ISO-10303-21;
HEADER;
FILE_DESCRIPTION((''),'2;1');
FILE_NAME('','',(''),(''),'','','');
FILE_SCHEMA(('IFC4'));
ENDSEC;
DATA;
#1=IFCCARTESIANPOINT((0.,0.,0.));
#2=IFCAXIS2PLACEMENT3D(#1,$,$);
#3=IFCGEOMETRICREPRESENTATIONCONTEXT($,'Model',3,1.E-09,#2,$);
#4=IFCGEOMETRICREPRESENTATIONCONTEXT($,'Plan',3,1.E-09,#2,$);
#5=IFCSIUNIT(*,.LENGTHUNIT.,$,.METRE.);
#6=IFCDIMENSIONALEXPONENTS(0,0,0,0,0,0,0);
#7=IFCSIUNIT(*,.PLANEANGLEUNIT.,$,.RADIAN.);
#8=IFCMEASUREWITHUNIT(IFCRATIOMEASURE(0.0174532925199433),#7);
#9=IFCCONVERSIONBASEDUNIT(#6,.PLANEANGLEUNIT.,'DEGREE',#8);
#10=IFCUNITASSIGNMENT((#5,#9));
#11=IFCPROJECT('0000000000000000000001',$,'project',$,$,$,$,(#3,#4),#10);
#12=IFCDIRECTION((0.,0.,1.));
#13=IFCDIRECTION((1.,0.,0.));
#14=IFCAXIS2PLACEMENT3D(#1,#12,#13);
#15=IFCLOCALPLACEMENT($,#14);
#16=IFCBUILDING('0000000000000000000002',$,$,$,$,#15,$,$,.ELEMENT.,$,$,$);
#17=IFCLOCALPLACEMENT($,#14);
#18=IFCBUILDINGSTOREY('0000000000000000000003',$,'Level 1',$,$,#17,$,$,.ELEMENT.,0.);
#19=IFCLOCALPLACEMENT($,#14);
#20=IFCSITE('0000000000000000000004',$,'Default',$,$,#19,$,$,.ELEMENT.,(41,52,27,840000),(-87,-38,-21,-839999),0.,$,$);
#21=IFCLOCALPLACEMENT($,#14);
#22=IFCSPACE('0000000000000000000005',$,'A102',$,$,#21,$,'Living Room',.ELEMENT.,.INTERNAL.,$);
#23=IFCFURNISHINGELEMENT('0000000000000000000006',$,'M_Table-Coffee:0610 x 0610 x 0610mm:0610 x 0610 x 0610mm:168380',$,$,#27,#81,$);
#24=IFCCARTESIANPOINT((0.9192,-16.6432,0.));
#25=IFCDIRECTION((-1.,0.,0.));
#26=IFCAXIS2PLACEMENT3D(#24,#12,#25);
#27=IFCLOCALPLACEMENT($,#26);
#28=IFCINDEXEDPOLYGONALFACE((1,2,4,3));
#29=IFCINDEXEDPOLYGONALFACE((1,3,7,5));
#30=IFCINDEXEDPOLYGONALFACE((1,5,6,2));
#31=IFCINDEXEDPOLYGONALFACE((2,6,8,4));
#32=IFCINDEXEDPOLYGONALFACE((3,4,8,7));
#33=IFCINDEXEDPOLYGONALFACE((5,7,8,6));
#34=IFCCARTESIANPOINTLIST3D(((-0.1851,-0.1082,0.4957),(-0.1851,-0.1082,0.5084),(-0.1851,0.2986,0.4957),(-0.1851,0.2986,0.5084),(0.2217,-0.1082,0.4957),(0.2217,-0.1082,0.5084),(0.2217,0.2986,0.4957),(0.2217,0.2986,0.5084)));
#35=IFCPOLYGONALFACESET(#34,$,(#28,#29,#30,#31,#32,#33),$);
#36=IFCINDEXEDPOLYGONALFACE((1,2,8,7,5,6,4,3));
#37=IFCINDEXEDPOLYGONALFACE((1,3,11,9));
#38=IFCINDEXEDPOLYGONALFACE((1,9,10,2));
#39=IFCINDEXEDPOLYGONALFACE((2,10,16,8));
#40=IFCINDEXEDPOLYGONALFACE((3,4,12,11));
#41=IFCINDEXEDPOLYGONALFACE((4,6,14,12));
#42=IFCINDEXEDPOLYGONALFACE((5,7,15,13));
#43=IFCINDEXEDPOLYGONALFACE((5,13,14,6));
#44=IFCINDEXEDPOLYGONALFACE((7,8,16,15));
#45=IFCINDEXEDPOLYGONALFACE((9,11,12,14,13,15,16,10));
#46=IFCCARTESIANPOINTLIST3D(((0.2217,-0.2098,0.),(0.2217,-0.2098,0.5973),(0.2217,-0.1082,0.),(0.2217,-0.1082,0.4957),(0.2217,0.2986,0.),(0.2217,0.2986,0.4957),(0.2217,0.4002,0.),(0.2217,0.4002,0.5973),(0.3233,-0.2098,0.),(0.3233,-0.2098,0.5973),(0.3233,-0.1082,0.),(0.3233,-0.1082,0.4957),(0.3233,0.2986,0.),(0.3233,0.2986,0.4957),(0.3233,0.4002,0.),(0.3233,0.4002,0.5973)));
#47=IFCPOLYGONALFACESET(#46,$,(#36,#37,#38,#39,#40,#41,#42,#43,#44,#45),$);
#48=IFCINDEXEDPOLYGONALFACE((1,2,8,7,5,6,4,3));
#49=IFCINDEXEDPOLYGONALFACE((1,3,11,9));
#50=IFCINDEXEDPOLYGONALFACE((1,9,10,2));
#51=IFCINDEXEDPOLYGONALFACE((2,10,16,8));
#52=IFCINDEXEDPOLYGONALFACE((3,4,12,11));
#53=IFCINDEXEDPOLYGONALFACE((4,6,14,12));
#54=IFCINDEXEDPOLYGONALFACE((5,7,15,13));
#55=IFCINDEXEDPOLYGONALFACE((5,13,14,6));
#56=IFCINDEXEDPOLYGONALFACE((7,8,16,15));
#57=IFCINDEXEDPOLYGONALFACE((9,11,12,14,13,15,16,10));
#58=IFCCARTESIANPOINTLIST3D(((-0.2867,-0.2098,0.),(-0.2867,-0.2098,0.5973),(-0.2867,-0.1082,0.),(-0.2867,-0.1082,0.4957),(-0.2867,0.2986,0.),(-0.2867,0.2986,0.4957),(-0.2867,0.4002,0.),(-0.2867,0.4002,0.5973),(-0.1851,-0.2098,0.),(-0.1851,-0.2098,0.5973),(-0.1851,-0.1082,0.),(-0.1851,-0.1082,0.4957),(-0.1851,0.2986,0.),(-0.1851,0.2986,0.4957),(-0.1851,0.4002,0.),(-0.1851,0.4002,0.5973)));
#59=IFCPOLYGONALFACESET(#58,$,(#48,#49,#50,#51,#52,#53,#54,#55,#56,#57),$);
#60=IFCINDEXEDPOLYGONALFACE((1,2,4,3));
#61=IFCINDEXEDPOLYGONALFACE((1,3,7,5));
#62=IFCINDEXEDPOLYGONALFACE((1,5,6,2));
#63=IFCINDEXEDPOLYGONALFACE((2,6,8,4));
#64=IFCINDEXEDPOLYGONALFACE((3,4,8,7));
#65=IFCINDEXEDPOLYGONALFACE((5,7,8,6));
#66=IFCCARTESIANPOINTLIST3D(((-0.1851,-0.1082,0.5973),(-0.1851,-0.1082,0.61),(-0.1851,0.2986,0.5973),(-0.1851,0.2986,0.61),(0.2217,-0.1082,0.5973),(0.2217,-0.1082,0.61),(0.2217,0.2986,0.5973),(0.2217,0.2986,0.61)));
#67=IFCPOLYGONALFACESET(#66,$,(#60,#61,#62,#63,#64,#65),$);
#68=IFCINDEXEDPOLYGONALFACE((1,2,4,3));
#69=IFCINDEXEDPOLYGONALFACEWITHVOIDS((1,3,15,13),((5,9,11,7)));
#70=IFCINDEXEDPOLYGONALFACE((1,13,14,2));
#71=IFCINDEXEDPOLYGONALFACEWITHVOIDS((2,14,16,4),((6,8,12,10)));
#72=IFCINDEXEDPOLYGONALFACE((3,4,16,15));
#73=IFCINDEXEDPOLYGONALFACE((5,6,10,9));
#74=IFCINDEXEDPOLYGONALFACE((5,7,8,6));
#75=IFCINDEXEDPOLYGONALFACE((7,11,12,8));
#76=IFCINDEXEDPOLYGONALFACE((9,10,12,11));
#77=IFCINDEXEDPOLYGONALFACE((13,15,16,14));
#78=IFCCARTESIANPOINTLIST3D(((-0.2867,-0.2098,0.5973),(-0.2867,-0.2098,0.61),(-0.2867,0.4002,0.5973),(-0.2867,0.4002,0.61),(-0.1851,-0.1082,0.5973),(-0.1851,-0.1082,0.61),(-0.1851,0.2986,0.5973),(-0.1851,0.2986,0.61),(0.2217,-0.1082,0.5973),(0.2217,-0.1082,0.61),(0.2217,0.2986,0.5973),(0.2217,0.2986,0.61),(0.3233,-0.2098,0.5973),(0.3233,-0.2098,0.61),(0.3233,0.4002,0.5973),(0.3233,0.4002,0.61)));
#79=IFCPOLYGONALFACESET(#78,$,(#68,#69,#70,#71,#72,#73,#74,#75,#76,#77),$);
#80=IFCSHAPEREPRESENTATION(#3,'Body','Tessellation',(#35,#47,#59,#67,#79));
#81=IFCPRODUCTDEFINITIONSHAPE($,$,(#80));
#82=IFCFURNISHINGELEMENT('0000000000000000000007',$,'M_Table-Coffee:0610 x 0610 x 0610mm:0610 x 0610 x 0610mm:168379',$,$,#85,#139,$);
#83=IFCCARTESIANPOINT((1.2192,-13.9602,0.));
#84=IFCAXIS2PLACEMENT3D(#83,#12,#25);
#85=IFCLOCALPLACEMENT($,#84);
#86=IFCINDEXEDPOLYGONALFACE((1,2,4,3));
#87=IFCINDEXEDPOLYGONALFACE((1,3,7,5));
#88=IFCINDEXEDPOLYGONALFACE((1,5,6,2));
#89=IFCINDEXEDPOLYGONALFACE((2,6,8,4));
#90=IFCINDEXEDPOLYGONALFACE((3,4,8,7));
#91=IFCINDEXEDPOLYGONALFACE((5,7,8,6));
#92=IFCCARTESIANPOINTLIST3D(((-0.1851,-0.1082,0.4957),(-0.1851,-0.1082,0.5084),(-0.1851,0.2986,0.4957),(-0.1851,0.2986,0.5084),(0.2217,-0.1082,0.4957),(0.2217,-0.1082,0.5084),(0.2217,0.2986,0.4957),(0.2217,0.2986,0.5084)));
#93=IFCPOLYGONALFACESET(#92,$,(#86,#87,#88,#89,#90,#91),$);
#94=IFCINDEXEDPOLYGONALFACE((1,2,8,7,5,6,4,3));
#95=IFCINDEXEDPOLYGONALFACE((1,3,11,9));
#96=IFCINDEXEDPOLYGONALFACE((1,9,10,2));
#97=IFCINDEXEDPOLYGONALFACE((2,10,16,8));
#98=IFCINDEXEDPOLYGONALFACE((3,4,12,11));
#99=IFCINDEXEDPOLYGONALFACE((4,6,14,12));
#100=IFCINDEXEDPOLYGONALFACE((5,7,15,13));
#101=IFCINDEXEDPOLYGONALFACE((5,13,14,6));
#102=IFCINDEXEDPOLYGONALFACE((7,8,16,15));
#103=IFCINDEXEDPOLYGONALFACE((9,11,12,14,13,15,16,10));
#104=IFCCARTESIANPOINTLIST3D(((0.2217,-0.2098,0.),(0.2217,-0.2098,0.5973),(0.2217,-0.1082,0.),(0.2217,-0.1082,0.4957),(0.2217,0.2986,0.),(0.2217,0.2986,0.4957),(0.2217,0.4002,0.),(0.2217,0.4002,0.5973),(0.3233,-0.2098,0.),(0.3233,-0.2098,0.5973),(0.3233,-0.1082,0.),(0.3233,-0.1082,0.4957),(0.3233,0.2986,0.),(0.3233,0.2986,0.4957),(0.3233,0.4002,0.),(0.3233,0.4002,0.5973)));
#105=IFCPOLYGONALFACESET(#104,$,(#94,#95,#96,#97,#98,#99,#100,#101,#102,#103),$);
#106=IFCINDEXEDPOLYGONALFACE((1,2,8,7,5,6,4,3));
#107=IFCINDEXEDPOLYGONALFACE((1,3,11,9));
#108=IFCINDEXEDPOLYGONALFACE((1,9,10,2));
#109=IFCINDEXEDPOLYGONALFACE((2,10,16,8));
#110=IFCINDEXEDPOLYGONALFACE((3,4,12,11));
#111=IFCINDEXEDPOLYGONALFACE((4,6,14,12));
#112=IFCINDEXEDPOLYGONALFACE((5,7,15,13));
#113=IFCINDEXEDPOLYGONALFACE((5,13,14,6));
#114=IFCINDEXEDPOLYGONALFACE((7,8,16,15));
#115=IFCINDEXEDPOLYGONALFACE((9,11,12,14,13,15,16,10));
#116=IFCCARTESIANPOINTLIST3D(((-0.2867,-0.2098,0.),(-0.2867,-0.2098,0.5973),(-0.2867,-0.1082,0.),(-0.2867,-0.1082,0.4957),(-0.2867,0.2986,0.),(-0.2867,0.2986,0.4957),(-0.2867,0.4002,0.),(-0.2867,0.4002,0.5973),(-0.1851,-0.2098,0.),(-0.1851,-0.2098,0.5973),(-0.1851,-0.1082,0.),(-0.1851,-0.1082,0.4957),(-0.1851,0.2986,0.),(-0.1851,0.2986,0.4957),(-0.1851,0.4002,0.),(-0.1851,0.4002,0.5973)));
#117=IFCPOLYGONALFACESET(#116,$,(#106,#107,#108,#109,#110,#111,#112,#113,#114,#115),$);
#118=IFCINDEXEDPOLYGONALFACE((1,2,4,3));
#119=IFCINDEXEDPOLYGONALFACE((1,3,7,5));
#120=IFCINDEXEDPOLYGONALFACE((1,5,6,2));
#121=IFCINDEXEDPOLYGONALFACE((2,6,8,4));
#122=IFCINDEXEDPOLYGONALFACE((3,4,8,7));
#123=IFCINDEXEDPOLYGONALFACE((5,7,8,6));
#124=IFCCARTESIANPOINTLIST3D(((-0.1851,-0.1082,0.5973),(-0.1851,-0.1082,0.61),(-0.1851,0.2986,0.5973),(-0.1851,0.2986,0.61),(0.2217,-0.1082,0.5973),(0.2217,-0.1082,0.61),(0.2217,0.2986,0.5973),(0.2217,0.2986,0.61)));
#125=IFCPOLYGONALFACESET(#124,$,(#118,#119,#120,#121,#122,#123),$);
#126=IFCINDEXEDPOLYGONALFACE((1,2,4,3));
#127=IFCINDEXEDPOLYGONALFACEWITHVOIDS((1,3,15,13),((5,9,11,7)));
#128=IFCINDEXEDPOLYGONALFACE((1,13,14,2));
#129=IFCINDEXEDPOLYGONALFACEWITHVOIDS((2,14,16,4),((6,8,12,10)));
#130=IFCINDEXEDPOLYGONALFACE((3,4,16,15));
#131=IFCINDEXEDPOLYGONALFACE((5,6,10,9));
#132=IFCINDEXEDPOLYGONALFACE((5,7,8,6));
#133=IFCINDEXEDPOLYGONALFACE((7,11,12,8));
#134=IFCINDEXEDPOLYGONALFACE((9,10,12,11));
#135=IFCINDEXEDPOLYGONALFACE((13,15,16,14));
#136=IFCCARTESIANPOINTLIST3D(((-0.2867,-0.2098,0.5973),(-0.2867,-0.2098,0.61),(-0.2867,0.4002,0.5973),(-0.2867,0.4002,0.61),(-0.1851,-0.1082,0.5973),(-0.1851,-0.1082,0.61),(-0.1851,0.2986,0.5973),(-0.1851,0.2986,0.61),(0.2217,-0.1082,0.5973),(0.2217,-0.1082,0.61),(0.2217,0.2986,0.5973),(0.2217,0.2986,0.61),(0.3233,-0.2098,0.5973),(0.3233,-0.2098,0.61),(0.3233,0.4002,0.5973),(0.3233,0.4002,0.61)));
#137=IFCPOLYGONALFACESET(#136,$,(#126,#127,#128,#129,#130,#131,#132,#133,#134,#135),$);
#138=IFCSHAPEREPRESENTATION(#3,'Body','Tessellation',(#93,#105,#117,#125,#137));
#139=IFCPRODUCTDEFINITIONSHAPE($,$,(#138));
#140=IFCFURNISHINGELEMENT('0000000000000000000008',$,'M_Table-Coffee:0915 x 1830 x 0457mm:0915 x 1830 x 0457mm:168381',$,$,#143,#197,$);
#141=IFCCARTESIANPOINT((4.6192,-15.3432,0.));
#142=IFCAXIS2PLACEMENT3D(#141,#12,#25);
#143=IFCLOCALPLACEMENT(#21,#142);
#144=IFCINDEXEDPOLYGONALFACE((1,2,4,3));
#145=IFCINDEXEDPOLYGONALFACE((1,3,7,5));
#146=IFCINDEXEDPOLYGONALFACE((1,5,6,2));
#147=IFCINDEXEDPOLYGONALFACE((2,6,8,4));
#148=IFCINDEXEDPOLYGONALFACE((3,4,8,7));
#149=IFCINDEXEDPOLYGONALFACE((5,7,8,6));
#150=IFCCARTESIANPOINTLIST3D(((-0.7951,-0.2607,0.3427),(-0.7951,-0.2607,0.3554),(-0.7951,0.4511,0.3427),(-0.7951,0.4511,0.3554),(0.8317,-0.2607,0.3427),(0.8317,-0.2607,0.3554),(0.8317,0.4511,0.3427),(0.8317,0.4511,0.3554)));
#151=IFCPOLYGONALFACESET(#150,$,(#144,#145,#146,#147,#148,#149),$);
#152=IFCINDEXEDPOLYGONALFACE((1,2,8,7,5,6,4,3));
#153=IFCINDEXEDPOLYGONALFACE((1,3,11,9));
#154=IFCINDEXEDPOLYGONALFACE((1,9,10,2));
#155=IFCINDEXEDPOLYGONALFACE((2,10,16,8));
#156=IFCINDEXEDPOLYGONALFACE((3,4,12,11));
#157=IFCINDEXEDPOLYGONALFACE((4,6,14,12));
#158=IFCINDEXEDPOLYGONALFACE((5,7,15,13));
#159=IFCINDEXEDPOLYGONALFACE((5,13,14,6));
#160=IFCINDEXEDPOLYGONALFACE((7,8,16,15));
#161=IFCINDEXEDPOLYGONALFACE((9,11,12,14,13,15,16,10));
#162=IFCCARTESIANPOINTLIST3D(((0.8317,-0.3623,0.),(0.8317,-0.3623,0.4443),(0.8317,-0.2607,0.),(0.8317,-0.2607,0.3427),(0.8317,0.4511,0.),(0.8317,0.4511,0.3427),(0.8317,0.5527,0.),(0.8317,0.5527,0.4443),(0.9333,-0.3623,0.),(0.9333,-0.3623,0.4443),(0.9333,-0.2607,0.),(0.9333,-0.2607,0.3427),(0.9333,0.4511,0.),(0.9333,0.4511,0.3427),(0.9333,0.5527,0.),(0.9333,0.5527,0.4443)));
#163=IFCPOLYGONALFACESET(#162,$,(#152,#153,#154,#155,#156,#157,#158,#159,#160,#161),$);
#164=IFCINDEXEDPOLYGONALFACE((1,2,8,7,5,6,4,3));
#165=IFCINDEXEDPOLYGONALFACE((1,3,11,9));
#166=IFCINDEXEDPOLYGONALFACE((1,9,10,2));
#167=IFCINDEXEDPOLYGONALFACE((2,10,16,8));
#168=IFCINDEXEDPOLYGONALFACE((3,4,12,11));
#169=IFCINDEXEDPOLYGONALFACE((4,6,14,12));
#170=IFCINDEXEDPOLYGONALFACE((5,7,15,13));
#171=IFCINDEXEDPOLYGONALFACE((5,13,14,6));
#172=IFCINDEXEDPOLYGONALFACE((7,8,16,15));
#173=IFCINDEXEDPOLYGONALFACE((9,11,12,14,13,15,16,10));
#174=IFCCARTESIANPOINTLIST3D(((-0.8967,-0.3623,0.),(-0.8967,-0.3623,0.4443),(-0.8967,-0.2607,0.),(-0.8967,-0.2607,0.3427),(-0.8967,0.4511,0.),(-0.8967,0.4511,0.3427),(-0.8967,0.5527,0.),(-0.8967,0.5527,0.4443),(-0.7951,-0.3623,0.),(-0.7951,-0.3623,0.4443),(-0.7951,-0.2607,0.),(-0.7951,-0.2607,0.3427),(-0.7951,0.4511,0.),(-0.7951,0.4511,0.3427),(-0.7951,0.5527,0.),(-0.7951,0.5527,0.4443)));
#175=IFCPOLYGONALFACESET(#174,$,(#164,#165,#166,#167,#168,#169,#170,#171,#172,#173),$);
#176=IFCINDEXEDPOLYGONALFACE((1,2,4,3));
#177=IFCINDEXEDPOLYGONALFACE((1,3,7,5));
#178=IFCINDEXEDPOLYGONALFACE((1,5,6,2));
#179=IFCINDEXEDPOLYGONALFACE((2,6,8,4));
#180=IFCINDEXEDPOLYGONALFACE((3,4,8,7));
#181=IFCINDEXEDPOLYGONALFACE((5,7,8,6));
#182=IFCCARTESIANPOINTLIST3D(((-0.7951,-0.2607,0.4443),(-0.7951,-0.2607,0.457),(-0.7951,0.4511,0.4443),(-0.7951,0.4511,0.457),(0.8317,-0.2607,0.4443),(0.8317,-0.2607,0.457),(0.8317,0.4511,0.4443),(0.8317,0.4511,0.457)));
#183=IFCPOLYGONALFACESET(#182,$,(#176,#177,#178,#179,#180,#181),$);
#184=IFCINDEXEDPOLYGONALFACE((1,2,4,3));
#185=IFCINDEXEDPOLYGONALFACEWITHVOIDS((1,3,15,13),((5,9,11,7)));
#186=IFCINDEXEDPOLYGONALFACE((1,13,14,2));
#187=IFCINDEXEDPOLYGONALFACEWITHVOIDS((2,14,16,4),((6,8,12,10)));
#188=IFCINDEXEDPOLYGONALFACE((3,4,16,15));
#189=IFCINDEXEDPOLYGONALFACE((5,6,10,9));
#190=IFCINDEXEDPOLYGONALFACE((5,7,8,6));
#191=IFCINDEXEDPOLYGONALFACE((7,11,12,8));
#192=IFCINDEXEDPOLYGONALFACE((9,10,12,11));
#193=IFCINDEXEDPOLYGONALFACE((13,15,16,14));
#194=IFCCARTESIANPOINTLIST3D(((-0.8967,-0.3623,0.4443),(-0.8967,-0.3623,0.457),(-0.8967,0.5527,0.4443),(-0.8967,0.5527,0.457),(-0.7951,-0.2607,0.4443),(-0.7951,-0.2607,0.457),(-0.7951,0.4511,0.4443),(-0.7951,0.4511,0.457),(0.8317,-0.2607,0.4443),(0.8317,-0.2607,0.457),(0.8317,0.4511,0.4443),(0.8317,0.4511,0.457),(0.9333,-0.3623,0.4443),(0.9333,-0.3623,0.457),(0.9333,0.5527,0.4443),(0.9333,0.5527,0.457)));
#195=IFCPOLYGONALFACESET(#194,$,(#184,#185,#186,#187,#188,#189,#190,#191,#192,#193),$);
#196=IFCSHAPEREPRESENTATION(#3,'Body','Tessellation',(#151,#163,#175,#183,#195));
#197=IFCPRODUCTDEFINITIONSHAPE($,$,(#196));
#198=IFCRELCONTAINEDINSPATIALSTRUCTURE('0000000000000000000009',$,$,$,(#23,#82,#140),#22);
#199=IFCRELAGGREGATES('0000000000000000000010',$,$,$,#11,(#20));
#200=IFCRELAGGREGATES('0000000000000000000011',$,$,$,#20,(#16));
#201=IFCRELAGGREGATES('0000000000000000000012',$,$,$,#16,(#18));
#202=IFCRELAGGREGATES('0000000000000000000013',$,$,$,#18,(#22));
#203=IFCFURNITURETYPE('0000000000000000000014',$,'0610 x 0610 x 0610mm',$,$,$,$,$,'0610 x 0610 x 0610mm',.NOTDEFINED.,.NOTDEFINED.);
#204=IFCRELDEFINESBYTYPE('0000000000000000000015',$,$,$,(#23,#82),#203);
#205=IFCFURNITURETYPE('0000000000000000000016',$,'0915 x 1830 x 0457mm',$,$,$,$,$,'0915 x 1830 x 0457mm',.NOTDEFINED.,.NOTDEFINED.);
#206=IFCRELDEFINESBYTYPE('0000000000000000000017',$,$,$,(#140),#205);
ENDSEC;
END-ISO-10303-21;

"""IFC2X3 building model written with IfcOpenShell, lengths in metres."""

from ifc_helpers import new_model, entity, si_unit, converted_unit, frame, origin, origin_with_axes, origin_2d_with_axis, place, context, project, spatial, polyline, rectangle, outline, extrude, source, transform, mapped, type_object, type_shapes, element, save


model = new_model("IFC2X3")

# Units and contexts
model_context = context("Model", 3, precision=1e-09, world=origin())
plan_context = context("Plan", 3, precision=1e-09, world=origin())
ifc_project = project(units=[si_unit("LENGTHUNIT", "METRE"), converted_unit("PLANEANGLEUNIT", "DEGREE", entity("IfcRatioMeasure", 0.0174532925199433), si_unit("PLANEANGLEUNIT", "RADIAN"), dimensions=[0, 0, 0, 0, 0, 0, 0])], contexts=[model_context, plan_context])

# Site, building, storey, space
site_placement = place(None, origin_with_axes())
site = spatial("IfcSite", under=ifc_project, at=site_placement, Name="Default", CompositionType="ELEMENT", RefLatitude=(41, 52, 27, 840000), RefLongitude=(-87, -38, -21, -839999), RefElevation=0.0)
building_placement = place(None, origin_with_axes())
building = spatial("IfcBuilding", under=site, at=building_placement, CompositionType="ELEMENT")
storey_placement = place(None, origin_with_axes())
storey = spatial("IfcBuildingStorey", under=building, at=storey_placement, Name="Level 1", CompositionType="ELEMENT", Elevation=0.0)
space_placement = place(None, origin_with_axes())
space = spatial("IfcSpace", under=storey, at=space_placement, Name="A102", LongName="Living Room", CompositionType="ELEMENT", InteriorOrExteriorSpace="INTERNAL")

# Furnishing elements
furniture_type_1 = type_object("IfcFurnitureType", Name="0610 x 0610 x 0610mm", ElementType="0610 x 0610 x 0610mm", AssemblyPlace="NOTDEFINED")
shared_shape_1 = source(origin(), model_context, "Body", "SweptSolid", [
    extrude(rectangle(XDim=0.4068, YDim=0.4068, at=origin_2d_with_axis()), frame((0.0183, 0.0952, 0.4957), z_axis=(0.0, 0.0, 1.0), x_axis=(-1.0, 0.0, 0.0)), (0.0, 0.0, 1.0), 0.0127),
    extrude(outline(polyline([(-0.2732, -0.305), (0.324, -0.305), (0.324, 0.305), (-0.2732, 0.305), (-0.2732, 0.2034), (0.2225, 0.2034), (0.2225, -0.2034), (-0.2732, -0.2034), (-0.2732, -0.305)])), frame((0.2217, 0.0952, 0.2732), z_axis=(1.0, 0.0, 0.0), x_axis=(0.0, 0.0, 1.0)), (0.0, 0.0, 1.0), 0.1016),
    extrude(outline(polyline([(-0.305, -0.3241), (0.305, -0.3241), (0.305, 0.2733), (0.2034, 0.2733), (0.2034, -0.2224), (-0.2034, -0.2224), (-0.2034, 0.2733), (-0.305, 0.2733), (-0.305, -0.3241)])), frame((-0.2867, 0.0952, 0.2733), z_axis=(1.0, 0.0, 0.0), x_axis=(0.0, -1.0, 0.0)), (0.0, 0.0, 1.0), 0.1016),
    extrude(rectangle(XDim=0.4068, YDim=0.4068, at=origin_2d_with_axis()), frame((0.0183, 0.0952, 0.5973), z_axis=(0.0, 0.0, 1.0), x_axis=(-1.0, 0.0, 0.0)), (0.0, 0.0, 1.0), 0.0127),
    extrude(outline(polyline([(-0.305, -0.305), (0.305, -0.305), (0.305, 0.305), (-0.305, 0.305), (-0.305, -0.305)]), holes=[polyline([(-0.2034, -0.2034), (-0.2034, 0.2034), (0.2034, 0.2034), (0.2034, -0.2034), (-0.2034, -0.2034)])]), frame((0.0183, 0.0952, 0.5973), z_axis=(0.0, 0.0, 1.0), x_axis=(-1.0, 0.0, 0.0)), (0.0, 0.0, 1.0), 0.0127),
])
type_shapes(furniture_type_1, [shared_shape_1])
for number, where, z_axis, x_axis, name in (
    (1, (0.9192, -16.6432, 0.0), (0.0, 0.0, 1.0), (-1.0, 0.0, 0.0), "M_Table-Coffee:0610 x 0610 x 0610mm:0610 x 0610 x 0610mm:168380"),
    (2, (1.2192, -13.9602, 0.0), (0.0, 0.0, 1.0), (-1.0, 0.0, 0.0), "M_Table-Coffee:0610 x 0610 x 0610mm:0610 x 0610 x 0610mm:168379"),
):
    element("IfcFurnishingElement", number, at=place(None, frame(where, z_axis=z_axis, x_axis=x_axis)), inside=space, type_object=furniture_type_1, Name=name, context=model_context, shape_type="MappedRepresentation", body=[
        mapped(shared_shape_1, transform((0.0, 0.0, 0.0), scale=1.0)),
    ])
furniture_type_2 = type_object("IfcFurnitureType", Name="0915 x 1830 x 0457mm", ElementType="0915 x 1830 x 0457mm", AssemblyPlace="NOTDEFINED")
shared_shape_2 = source(origin(), model_context, "Body", "SweptSolid", [
    extrude(rectangle(XDim=1.6268, YDim=0.7118, at=origin_2d_with_axis()), frame((0.0183, 0.0952, 0.3427), z_axis=(0.0, 0.0, 1.0), x_axis=(-1.0, 0.0, 0.0)), (0.0, 0.0, 1.0), 0.0127),
    extrude(outline(polyline([(-0.1967, -0.4575), (0.2475, -0.4575), (0.2475, 0.4575), (-0.1967, 0.4575), (-0.1967, 0.3559), (0.146, 0.3559), (0.146, -0.3559), (-0.1967, -0.3559), (-0.1967, -0.4575)])), frame((0.8317, 0.0952, 0.1967), z_axis=(1.0, 0.0, 0.0), x_axis=(0.0, 0.0, 1.0)), (0.0, 0.0, 1.0), 0.1016),
    extrude(outline(polyline([(-0.4575, -0.2476), (0.4575, -0.2476), (0.4575, 0.1968), (0.3559, 0.1968), (0.3559, -0.1459), (-0.3559, -0.1459), (-0.3559, 0.1968), (-0.4575, 0.1968), (-0.4575, -0.2476)])), frame((-0.8967, 0.0952, 0.1968), z_axis=(1.0, 0.0, 0.0), x_axis=(0.0, -1.0, 0.0)), (0.0, 0.0, 1.0), 0.1016),
    extrude(rectangle(XDim=1.6268, YDim=0.7118, at=origin_2d_with_axis()), frame((0.0183, 0.0952, 0.4443), z_axis=(0.0, 0.0, 1.0), x_axis=(-1.0, 0.0, 0.0)), (0.0, 0.0, 1.0), 0.0127),
    extrude(outline(polyline([(-0.915, -0.4575), (0.915, -0.4575), (0.915, 0.4575), (-0.915, 0.4575), (-0.915, -0.4575)]), holes=[polyline([(-0.8134, -0.3559), (-0.8134, 0.3559), (0.8134, 0.3559), (0.8134, -0.3559), (-0.8134, -0.3559)])]), frame((0.0183, 0.0952, 0.4443), z_axis=(0.0, 0.0, 1.0), x_axis=(-1.0, 0.0, 0.0)), (0.0, 0.0, 1.0), 0.0127),
])
type_shapes(furniture_type_2, [shared_shape_2])
furnishing_placement = place(space_placement, frame((4.6192, -15.3432, 0.0), z_axis=(0.0, 0.0, 1.0), x_axis=(-1.0, 0.0, 0.0)))
element("IfcFurnishingElement", 3, at=furnishing_placement, inside=space, type_object=furniture_type_2, Name="M_Table-Coffee:0915 x 1830 x 0457mm:0915 x 1830 x 0457mm:168381", context=model_context, shape_type="MappedRepresentation", body=[
    mapped(shared_shape_2, transform((0.0, 0.0, 0.0), scale=1.0)),
])

save(model, "model.ifc")
